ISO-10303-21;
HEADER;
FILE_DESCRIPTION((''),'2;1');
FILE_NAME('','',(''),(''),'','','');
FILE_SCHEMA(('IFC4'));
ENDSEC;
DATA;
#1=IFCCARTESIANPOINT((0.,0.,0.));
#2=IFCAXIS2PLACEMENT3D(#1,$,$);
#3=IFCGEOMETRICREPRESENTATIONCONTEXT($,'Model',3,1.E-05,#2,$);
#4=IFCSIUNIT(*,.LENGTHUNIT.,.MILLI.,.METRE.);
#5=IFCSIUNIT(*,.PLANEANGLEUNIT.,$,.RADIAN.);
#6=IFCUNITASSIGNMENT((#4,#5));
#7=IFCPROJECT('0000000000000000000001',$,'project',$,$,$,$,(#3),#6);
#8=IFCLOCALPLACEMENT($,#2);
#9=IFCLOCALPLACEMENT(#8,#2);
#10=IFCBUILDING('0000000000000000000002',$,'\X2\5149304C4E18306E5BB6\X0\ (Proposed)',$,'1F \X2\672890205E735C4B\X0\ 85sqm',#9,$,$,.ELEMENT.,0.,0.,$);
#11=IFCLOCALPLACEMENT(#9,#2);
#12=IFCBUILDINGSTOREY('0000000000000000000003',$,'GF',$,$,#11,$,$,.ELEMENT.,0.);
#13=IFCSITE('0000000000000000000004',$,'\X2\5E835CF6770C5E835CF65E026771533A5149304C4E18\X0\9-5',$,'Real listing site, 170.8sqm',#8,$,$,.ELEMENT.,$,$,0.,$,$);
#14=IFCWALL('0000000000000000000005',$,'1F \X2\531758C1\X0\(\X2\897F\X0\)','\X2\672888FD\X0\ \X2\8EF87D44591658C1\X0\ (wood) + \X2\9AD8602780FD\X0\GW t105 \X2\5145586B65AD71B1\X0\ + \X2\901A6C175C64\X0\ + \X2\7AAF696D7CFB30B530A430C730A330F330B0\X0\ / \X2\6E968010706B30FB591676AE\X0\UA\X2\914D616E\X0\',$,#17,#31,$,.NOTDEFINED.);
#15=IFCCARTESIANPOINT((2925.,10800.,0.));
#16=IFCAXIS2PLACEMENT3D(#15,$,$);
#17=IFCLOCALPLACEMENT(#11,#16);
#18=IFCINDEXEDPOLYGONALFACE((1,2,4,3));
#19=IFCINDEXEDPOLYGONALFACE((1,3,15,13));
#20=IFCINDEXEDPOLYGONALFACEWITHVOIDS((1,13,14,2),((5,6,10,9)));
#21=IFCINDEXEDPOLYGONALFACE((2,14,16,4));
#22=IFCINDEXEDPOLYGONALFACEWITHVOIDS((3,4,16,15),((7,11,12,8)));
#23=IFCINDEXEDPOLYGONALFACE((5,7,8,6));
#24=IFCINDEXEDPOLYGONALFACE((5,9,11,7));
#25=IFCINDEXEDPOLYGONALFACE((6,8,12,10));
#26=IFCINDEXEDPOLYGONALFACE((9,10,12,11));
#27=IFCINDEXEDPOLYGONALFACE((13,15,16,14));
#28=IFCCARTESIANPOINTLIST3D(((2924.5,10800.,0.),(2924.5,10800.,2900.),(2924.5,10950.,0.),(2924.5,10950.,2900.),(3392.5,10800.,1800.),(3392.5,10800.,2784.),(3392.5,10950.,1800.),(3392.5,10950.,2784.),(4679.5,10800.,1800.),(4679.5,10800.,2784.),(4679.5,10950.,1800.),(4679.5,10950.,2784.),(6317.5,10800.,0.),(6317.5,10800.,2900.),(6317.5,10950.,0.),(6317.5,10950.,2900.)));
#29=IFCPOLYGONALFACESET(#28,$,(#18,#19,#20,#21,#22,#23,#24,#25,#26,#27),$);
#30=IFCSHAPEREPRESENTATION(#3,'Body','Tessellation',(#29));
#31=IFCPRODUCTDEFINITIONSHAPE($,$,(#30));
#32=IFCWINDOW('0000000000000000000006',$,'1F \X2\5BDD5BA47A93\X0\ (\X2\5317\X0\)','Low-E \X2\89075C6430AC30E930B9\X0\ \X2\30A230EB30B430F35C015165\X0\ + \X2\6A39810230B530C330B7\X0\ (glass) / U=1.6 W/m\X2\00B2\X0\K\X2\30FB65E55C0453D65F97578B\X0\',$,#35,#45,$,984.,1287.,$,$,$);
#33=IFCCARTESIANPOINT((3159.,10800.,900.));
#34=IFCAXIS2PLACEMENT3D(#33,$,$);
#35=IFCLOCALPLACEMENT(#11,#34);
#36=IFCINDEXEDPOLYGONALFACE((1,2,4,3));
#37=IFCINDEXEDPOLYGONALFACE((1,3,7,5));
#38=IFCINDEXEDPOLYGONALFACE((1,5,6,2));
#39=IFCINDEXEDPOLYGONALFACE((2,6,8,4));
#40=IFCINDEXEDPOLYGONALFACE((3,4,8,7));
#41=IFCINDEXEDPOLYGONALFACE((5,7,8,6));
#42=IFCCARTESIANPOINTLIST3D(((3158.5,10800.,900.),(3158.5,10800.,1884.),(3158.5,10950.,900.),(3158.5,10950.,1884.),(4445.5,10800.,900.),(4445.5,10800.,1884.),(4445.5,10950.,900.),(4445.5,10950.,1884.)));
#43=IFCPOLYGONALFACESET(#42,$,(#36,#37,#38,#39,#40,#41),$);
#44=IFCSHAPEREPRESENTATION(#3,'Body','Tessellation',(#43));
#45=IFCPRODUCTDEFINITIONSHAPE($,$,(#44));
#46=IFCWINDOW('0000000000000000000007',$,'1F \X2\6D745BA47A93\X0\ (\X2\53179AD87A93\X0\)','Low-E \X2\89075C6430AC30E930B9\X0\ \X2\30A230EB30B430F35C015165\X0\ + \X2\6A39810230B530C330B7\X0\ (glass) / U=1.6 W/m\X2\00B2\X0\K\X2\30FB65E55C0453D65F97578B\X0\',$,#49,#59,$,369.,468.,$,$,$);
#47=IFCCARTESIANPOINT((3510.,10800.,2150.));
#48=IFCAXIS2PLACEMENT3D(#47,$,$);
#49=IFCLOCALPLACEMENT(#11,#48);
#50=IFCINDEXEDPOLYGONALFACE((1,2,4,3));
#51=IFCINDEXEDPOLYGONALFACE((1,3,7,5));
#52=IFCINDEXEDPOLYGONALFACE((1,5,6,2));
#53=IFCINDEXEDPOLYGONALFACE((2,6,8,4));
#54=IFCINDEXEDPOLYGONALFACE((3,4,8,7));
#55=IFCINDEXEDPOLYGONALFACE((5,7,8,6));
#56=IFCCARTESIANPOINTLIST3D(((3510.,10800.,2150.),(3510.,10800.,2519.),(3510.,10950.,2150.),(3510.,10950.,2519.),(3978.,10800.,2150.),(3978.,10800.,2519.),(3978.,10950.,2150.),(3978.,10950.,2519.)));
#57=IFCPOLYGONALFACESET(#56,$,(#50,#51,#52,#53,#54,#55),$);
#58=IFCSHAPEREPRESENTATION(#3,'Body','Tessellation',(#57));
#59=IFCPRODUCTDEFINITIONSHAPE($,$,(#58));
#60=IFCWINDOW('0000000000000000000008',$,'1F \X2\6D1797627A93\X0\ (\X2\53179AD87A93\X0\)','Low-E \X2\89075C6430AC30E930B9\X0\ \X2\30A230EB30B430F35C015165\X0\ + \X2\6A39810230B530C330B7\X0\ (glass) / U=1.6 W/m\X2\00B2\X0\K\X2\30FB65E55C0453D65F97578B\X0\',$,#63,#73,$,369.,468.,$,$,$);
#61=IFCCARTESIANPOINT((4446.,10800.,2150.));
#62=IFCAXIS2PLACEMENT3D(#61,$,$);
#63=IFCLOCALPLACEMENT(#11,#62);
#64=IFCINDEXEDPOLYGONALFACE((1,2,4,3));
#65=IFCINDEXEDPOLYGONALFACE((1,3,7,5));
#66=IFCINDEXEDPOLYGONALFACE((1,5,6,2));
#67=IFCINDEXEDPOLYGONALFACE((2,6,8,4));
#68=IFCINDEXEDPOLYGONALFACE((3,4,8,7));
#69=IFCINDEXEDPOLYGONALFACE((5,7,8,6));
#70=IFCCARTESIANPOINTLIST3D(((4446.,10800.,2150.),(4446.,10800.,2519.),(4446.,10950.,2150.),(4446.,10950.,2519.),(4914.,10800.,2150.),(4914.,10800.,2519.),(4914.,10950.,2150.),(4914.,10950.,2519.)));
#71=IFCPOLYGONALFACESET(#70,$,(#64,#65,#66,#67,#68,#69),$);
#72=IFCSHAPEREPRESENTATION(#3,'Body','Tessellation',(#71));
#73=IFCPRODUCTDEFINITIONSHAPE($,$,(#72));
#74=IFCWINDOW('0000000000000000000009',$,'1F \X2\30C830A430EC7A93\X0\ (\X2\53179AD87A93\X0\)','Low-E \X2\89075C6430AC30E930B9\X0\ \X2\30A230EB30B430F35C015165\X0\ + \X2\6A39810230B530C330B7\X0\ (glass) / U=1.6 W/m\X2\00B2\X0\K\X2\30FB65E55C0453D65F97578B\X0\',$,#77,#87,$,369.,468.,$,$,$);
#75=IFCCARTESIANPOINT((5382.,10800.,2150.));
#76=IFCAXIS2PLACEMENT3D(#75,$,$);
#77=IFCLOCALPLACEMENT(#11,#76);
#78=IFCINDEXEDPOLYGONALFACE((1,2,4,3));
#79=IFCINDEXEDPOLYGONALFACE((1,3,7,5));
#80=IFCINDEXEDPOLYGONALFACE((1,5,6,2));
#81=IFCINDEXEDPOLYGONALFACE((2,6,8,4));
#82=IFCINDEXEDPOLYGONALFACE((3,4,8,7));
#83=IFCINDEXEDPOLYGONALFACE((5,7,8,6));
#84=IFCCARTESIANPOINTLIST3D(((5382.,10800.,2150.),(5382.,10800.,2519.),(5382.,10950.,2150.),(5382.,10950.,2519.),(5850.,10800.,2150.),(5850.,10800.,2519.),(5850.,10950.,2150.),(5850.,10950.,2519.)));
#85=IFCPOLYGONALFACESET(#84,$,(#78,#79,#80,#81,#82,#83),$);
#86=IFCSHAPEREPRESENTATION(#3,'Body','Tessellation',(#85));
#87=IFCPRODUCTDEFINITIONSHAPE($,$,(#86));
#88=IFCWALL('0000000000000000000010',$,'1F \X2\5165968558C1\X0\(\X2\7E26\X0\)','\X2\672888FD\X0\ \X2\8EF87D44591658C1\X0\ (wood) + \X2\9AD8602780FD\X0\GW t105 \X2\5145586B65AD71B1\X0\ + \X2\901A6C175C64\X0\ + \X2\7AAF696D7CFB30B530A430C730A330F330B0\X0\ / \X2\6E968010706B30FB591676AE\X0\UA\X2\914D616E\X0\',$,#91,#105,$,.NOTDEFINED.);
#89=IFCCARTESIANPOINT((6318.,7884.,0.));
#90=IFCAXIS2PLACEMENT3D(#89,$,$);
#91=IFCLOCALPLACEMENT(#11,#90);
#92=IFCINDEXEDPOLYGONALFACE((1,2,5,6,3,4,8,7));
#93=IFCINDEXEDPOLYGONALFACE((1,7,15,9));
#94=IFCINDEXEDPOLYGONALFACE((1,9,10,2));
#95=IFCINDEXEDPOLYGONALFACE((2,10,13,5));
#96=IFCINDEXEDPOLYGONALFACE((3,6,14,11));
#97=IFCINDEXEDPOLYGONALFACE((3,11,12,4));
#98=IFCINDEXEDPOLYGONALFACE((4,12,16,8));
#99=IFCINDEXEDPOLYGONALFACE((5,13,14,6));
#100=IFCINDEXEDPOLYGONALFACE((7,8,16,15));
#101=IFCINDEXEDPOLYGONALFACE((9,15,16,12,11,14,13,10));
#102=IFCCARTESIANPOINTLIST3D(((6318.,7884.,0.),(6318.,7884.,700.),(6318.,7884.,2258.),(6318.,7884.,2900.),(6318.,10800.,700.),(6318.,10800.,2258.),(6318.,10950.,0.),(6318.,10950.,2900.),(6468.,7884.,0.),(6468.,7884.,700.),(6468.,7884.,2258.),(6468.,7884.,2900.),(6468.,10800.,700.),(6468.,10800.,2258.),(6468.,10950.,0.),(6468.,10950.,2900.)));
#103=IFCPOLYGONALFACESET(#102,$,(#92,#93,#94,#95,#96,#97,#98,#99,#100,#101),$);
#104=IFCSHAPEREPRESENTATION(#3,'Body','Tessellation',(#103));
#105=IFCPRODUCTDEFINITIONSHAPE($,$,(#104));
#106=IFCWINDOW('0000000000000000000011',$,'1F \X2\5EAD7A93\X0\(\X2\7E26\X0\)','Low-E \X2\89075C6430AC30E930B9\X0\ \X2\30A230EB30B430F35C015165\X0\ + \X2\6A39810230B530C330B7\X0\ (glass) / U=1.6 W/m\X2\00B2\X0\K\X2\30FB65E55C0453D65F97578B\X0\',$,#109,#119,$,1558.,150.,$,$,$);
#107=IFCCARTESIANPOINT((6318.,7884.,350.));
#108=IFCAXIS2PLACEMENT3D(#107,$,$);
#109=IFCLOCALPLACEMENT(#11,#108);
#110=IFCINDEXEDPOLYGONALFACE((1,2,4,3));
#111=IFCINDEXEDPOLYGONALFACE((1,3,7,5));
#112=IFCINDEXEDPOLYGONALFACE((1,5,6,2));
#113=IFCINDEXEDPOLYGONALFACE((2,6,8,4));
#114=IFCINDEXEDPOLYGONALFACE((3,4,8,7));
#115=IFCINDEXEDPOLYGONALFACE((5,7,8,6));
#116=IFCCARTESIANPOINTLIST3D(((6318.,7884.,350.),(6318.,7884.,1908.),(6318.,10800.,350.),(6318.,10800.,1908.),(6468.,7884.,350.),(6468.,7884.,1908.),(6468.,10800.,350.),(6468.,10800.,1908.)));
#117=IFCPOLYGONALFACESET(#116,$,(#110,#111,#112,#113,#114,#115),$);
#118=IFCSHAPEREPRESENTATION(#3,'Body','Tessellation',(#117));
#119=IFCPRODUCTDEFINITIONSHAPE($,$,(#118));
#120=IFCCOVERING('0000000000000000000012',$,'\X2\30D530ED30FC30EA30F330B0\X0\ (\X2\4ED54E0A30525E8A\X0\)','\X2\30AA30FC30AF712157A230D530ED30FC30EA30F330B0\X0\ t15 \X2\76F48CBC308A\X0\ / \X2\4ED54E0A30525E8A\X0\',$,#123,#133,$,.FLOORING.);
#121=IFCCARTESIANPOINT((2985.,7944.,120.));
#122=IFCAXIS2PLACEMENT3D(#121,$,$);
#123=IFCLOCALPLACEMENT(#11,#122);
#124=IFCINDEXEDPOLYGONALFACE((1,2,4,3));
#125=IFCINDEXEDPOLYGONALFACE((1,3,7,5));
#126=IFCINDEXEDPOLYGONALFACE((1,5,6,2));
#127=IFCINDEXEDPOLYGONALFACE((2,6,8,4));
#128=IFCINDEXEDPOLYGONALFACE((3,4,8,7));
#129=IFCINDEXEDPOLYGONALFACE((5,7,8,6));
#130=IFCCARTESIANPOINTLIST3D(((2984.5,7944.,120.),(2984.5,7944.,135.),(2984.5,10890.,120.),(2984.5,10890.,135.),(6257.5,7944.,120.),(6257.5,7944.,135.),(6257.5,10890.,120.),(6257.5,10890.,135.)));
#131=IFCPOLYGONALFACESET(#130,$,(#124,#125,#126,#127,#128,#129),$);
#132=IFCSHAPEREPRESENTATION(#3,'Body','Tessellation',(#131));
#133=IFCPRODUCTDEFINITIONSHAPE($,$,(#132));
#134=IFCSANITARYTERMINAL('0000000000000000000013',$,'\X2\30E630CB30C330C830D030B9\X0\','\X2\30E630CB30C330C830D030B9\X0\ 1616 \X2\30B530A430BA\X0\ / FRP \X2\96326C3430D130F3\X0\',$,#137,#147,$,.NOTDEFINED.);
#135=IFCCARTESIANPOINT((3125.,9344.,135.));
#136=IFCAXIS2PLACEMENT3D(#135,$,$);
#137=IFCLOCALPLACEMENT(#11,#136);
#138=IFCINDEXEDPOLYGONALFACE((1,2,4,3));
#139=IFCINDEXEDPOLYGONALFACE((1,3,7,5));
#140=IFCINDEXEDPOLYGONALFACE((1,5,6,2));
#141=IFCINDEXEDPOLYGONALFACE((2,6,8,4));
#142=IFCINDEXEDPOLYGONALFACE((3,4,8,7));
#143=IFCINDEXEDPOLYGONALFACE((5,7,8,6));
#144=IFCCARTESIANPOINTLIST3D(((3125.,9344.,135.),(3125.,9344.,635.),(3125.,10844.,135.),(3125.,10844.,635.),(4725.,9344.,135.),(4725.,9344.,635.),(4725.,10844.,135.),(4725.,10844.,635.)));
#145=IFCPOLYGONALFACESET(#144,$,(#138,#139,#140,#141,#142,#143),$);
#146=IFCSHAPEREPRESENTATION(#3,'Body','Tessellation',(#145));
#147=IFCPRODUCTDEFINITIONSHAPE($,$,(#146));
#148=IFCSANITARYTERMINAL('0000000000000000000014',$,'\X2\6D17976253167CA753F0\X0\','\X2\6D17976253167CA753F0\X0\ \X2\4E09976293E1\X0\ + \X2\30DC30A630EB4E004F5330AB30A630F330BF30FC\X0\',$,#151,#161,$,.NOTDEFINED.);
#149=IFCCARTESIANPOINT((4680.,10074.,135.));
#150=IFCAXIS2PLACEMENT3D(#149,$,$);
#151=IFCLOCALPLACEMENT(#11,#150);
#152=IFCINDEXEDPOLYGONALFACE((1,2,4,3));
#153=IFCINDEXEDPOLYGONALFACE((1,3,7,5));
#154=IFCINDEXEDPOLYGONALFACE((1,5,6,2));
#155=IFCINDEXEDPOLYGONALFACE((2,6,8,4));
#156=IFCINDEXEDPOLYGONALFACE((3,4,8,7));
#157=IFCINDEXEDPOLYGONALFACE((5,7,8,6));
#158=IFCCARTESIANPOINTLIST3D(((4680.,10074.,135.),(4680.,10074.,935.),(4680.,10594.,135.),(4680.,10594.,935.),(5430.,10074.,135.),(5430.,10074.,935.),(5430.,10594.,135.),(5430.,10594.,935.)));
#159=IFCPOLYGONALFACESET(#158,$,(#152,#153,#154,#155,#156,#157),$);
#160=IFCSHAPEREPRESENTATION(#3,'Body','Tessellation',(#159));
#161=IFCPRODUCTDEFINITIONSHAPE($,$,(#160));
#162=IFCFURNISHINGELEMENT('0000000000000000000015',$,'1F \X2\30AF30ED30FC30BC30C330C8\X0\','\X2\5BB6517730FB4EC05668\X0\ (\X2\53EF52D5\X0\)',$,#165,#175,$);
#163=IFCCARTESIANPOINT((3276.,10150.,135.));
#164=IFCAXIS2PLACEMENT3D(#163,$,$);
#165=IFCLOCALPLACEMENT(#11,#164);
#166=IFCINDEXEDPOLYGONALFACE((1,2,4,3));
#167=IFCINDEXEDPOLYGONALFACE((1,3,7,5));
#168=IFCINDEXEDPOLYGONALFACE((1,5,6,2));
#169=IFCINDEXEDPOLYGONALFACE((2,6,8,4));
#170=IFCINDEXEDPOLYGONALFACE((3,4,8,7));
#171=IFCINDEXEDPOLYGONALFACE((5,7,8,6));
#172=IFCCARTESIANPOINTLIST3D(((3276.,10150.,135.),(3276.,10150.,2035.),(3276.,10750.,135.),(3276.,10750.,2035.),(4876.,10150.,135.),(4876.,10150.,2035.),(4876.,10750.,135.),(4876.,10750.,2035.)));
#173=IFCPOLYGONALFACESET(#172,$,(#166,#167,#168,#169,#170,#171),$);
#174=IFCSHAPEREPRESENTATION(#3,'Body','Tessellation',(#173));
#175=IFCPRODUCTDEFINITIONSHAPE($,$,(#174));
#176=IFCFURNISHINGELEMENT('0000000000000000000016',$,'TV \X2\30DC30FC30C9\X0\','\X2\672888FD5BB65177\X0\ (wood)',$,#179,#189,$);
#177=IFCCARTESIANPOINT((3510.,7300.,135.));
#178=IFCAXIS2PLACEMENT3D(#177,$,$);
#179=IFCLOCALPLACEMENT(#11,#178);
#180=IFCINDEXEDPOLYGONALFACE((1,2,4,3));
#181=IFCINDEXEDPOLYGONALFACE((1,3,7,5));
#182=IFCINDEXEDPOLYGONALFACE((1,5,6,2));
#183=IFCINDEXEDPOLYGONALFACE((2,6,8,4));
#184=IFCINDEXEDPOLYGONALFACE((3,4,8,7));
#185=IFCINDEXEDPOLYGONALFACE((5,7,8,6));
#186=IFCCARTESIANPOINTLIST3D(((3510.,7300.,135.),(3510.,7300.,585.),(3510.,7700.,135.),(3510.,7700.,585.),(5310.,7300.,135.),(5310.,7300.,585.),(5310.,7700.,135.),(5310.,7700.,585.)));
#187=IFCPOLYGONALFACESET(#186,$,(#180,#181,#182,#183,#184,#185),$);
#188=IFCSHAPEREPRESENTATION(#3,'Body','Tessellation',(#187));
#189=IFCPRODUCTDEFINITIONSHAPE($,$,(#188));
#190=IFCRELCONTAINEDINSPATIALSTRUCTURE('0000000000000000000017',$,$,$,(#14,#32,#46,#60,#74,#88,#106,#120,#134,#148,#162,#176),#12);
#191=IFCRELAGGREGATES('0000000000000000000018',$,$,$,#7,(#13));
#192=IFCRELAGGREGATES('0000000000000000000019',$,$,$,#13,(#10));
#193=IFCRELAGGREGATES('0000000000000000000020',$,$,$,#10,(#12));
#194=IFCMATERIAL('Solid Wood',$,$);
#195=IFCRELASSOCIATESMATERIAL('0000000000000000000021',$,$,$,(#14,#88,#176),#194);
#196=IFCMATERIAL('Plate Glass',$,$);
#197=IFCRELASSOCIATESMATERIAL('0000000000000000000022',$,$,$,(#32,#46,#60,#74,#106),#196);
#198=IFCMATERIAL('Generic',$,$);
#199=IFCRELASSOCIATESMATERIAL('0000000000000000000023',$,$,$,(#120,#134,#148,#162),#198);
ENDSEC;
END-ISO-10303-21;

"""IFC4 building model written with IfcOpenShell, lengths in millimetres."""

from ifc_helpers import new_model, si_unit, frame, frame_2d, origin, place, context, project, spatial, rectangle, extrude, material, element, fill, save


model = new_model("IFC4")

# Units and contexts
model_context = context("Model", 3, precision=1e-05, world=origin())
ifc_project = project(units=[si_unit("LENGTHUNIT", "METRE", prefix="MILLI"), si_unit("PLANEANGLEUNIT", "RADIAN")], contexts=[model_context])

# Site, building, storey
site_placement = place(None, origin())
site = spatial("IfcSite", under=ifc_project, at=site_placement, Name="広島県広島市東区光が丘9-5", ObjectType="Real listing site, 170.8sqm", CompositionType="ELEMENT", RefElevation=0.0)
building_placement = place(site_placement, origin())
building = spatial("IfcBuilding", under=site, at=building_placement, Name="光が丘の家 (Proposed)", ObjectType="1F 木造平屋 85sqm", CompositionType="ELEMENT", ElevationOfRefHeight=0.0, ElevationOfTerrain=0.0)
storey_placement = place(building_placement, origin())
storey = spatial("IfcBuildingStorey", under=building, at=storey_placement, Name="GF", CompositionType="ELEMENT", Elevation=0.0)

# Shared definitions
ifc_material_1 = material(Name="Solid Wood")

# Wall, openings, windows
wall_1_placement = place(storey_placement, frame((2925.0, 10800.0, 0.0)))
wall_1 = element("IfcWall", 1, at=wall_1_placement, inside=storey, material=ifc_material_1, Name="1F 北壁(西)", Description="木製 軸組外壁 (wood) + 高性能GW t105 充填断熱 + 通気層 + 窯業系サイディング / 準耐火・外皮UA配慮", PredefinedType="NOTDEFINED", context=model_context, shape_type="SweptSolid", body=[
    extrude(rectangle(XDim=3393.0, YDim=150.0, at=frame_2d((1696.0, 75.0))), frame((2925.0, 10800.0, 0.0)), (0.0, 0.0, 1.0), 2900.0),
])
opening_1_placement = place(storey_placement, frame((3159.0, 10800.0, 900.0)))
opening_1 = element("IfcOpeningElement", 2, at=opening_1_placement, cuts=wall_1, PredefinedType="NOTDEFINED", context=model_context, shape_type="SweptSolid", body=[
    extrude(rectangle(XDim=1287.0, YDim=150.0, at=frame_2d((643.0, 75.0))), frame((3159.0, 10800.0, 900.0)), (0.0, 0.0, 1.0), 984.0),
])
opening_2_placement = place(storey_placement, frame((3510.0, 10800.0, 2150.0)))
opening_2 = element("IfcOpeningElement", 3, at=opening_2_placement, cuts=wall_1, PredefinedType="NOTDEFINED", context=model_context, shape_type="SweptSolid", body=[
    extrude(rectangle(XDim=468.0, YDim=150.0, at=frame_2d((234.0, 75.0))), frame((3510.0, 10800.0, 2150.0)), (0.0, 0.0, 1.0), 369.0),
])
opening_3_placement = place(storey_placement, frame((4446.0, 10800.0, 2150.0)))
opening_3 = element("IfcOpeningElement", 4, at=opening_3_placement, cuts=wall_1, PredefinedType="NOTDEFINED", context=model_context, shape_type="SweptSolid", body=[
    extrude(rectangle(XDim=468.0, YDim=150.0, at=frame_2d((234.0, 75.0))), frame((4446.0, 10800.0, 2150.0)), (0.0, 0.0, 1.0), 369.0),
])
opening_4_placement = place(storey_placement, frame((5382.0, 10800.0, 2150.0)))
opening_4 = element("IfcOpeningElement", 5, at=opening_4_placement, cuts=wall_1, PredefinedType="NOTDEFINED", context=model_context, shape_type="SweptSolid", body=[
    extrude(rectangle(XDim=468.0, YDim=150.0, at=frame_2d((234.0, 75.0))), frame((5382.0, 10800.0, 2150.0)), (0.0, 0.0, 1.0), 369.0),
])
ifc_material_2 = material(Name="Plate Glass")
window_1_placement = place(storey_placement, frame((3159.0, 10800.0, 900.0)))
window_1 = element("IfcWindow", 6, at=window_1_placement, inside=storey, material=ifc_material_2, Name="1F 寝室窓 (北)", Description="Low-E 複層ガラス アルゴン封入 + 樹脂サッシ (glass) / U=1.6 W/m²K・日射取得型", OverallHeight=984.0, OverallWidth=1287.0, context=model_context, shape_type="SweptSolid", body=[
    extrude(rectangle(XDim=1287.0, YDim=150.0, at=frame_2d((643.0, 75.0))), frame((3159.0, 10800.0, 900.0)), (0.0, 0.0, 1.0), 984.0),
])
fill(opening_1, window_1)
window_2_placement = place(storey_placement, frame((3510.0, 10800.0, 2150.0)))
window_2 = element("IfcWindow", 7, at=window_2_placement, inside=storey, material=ifc_material_2, Name="1F 浴室窓 (北高窓)", Description="Low-E 複層ガラス アルゴン封入 + 樹脂サッシ (glass) / U=1.6 W/m²K・日射取得型", OverallHeight=369.0, OverallWidth=468.0, context=model_context, shape_type="SweptSolid", body=[
    extrude(rectangle(XDim=468.0, YDim=150.0, at=frame_2d((234.0, 75.0))), frame((3510.0, 10800.0, 2150.0)), (0.0, 0.0, 1.0), 369.0),
])
fill(opening_2, window_2)
window_3_placement = place(storey_placement, frame((4446.0, 10800.0, 2150.0)))
window_3 = element("IfcWindow", 8, at=window_3_placement, inside=storey, material=ifc_material_2, Name="1F 洗面窓 (北高窓)", Description="Low-E 複層ガラス アルゴン封入 + 樹脂サッシ (glass) / U=1.6 W/m²K・日射取得型", OverallHeight=369.0, OverallWidth=468.0, context=model_context, shape_type="SweptSolid", body=[
    extrude(rectangle(XDim=468.0, YDim=150.0, at=frame_2d((234.0, 75.0))), frame((4446.0, 10800.0, 2150.0)), (0.0, 0.0, 1.0), 369.0),
])
fill(opening_3, window_3)
window_4_placement = place(storey_placement, frame((5382.0, 10800.0, 2150.0)))
window_4 = element("IfcWindow", 9, at=window_4_placement, inside=storey, material=ifc_material_2, Name="1F トイレ窓 (北高窓)", Description="Low-E 複層ガラス アルゴン封入 + 樹脂サッシ (glass) / U=1.6 W/m²K・日射取得型", OverallHeight=369.0, OverallWidth=468.0, context=model_context, shape_type="SweptSolid", body=[
    extrude(rectangle(XDim=468.0, YDim=150.0, at=frame_2d((234.0, 75.0))), frame((5382.0, 10800.0, 2150.0)), (0.0, 0.0, 1.0), 369.0),
])
fill(opening_4, window_4)

# Wall, opening, window
wall_2_placement = place(storey_placement, frame((6318.0, 7884.0, 0.0)))
wall_2 = element("IfcWall", 10, at=wall_2_placement, inside=storey, material=ifc_material_1, Name="1F 入隅壁(縦)", Description="木製 軸組外壁 (wood) + 高性能GW t105 充填断熱 + 通気層 + 窯業系サイディング / 準耐火・外皮UA配慮", PredefinedType="NOTDEFINED", context=model_context, shape_type="SweptSolid", body=[
    extrude(rectangle(XDim=150.0, YDim=3066.0, at=frame_2d((75.0, 1533.0))), frame((6318.0, 7884.0, 0.0)), (0.0, 0.0, 1.0), 2900.0),
])
opening_5_placement = place(storey_placement, frame((6318.0, 7884.0, 350.0)))
opening_5 = element("IfcOpeningElement", 11, at=opening_5_placement, cuts=wall_2, PredefinedType="NOTDEFINED", context=model_context, shape_type="SweptSolid", body=[
    extrude(rectangle(XDim=150.0, YDim=2916.0, at=frame_2d((75.0, 1458.0))), frame((6318.0, 7884.0, 350.0)), (0.0, 0.0, 1.0), 1558.0),
])
window_5_placement = place(storey_placement, frame((6318.0, 7884.0, 350.0)))
window_5 = element("IfcWindow", 12, at=window_5_placement, inside=storey, material=ifc_material_2, Name="1F 庭窓(縦)", Description="Low-E 複層ガラス アルゴン封入 + 樹脂サッシ (glass) / U=1.6 W/m²K・日射取得型", OverallHeight=1558.0, OverallWidth=150.0, context=model_context, shape_type="SweptSolid", body=[
    extrude(rectangle(XDim=150.0, YDim=2916.0, at=frame_2d((75.0, 1458.0))), frame((6318.0, 7884.0, 350.0)), (0.0, 0.0, 1.0), 1558.0),
])
fill(opening_5, window_5)

# Covering
ifc_material_3 = material(Name="Generic")
covering_placement = place(storey_placement, frame((2985.0, 7944.0, 120.0)))
element("IfcCovering", 13, at=covering_placement, inside=storey, material=ifc_material_3, Name="フローリング (仕上げ床)", Description="オーク無垢フローリング t15 直貼り / 仕上げ床", PredefinedType="FLOORING", context=model_context, shape_type="SweptSolid", body=[
    extrude(rectangle(XDim=3273.0, YDim=2946.0, at=frame_2d((1636.0, 1473.0))), frame((2985.0, 7944.0, 120.0)), (0.0, 0.0, 1.0), 15.0),
])

# Sanitary terminals
sanitary_terminal_1_placement = place(storey_placement, frame((3125.0, 9344.0, 135.0)))
element("IfcSanitaryTerminal", 14, at=sanitary_terminal_1_placement, inside=storey, material=ifc_material_3, Name="ユニットバス", Description="ユニットバス 1616 サイズ / FRP 防水パン", PredefinedType="NOTDEFINED", context=model_context, shape_type="SweptSolid", body=[
    extrude(rectangle(XDim=1600.0, YDim=1500.0, at=frame_2d((800.0, 750.0))), frame((3125.0, 9344.0, 135.0)), (0.0, 0.0, 1.0), 500.0),
])
sanitary_terminal_2_placement = place(storey_placement, frame((4680.0, 10074.0, 135.0)))
element("IfcSanitaryTerminal", 15, at=sanitary_terminal_2_placement, inside=storey, material=ifc_material_3, Name="洗面化粧台", Description="洗面化粧台 三面鏡 + ボウル一体カウンター", PredefinedType="NOTDEFINED", context=model_context, shape_type="SweptSolid", body=[
    extrude(rectangle(XDim=750.0, YDim=520.0, at=frame_2d((375.0, 260.0))), frame((4680.0, 10074.0, 135.0)), (0.0, 0.0, 1.0), 800.0),
])

# Furnishing elements
furnishing_1_placement = place(storey_placement, frame((3276.0, 10150.0, 135.0)))
element("IfcFurnishingElement", 16, at=furnishing_1_placement, inside=storey, material=ifc_material_3, Name="1F クローゼット", Description="家具・什器 (可動)", context=model_context, shape_type="SweptSolid", body=[
    extrude(rectangle(XDim=1600.0, YDim=600.0, at=frame_2d((800.0, 300.0))), frame((3276.0, 10150.0, 135.0)), (0.0, 0.0, 1.0), 1900.0),
])
furnishing_2_placement = place(storey_placement, frame((3510.0, 7300.0, 135.0)))
element("IfcFurnishingElement", 17, at=furnishing_2_placement, inside=storey, material=ifc_material_1, Name="TV ボード", Description="木製家具 (wood)", context=model_context, shape_type="SweptSolid", body=[
    extrude(rectangle(XDim=1800.0, YDim=400.0, at=frame_2d((900.0, 200.0))), frame((3510.0, 7300.0, 135.0)), (0.0, 0.0, 1.0), 450.0),
])

save(model, "model.ifc")
